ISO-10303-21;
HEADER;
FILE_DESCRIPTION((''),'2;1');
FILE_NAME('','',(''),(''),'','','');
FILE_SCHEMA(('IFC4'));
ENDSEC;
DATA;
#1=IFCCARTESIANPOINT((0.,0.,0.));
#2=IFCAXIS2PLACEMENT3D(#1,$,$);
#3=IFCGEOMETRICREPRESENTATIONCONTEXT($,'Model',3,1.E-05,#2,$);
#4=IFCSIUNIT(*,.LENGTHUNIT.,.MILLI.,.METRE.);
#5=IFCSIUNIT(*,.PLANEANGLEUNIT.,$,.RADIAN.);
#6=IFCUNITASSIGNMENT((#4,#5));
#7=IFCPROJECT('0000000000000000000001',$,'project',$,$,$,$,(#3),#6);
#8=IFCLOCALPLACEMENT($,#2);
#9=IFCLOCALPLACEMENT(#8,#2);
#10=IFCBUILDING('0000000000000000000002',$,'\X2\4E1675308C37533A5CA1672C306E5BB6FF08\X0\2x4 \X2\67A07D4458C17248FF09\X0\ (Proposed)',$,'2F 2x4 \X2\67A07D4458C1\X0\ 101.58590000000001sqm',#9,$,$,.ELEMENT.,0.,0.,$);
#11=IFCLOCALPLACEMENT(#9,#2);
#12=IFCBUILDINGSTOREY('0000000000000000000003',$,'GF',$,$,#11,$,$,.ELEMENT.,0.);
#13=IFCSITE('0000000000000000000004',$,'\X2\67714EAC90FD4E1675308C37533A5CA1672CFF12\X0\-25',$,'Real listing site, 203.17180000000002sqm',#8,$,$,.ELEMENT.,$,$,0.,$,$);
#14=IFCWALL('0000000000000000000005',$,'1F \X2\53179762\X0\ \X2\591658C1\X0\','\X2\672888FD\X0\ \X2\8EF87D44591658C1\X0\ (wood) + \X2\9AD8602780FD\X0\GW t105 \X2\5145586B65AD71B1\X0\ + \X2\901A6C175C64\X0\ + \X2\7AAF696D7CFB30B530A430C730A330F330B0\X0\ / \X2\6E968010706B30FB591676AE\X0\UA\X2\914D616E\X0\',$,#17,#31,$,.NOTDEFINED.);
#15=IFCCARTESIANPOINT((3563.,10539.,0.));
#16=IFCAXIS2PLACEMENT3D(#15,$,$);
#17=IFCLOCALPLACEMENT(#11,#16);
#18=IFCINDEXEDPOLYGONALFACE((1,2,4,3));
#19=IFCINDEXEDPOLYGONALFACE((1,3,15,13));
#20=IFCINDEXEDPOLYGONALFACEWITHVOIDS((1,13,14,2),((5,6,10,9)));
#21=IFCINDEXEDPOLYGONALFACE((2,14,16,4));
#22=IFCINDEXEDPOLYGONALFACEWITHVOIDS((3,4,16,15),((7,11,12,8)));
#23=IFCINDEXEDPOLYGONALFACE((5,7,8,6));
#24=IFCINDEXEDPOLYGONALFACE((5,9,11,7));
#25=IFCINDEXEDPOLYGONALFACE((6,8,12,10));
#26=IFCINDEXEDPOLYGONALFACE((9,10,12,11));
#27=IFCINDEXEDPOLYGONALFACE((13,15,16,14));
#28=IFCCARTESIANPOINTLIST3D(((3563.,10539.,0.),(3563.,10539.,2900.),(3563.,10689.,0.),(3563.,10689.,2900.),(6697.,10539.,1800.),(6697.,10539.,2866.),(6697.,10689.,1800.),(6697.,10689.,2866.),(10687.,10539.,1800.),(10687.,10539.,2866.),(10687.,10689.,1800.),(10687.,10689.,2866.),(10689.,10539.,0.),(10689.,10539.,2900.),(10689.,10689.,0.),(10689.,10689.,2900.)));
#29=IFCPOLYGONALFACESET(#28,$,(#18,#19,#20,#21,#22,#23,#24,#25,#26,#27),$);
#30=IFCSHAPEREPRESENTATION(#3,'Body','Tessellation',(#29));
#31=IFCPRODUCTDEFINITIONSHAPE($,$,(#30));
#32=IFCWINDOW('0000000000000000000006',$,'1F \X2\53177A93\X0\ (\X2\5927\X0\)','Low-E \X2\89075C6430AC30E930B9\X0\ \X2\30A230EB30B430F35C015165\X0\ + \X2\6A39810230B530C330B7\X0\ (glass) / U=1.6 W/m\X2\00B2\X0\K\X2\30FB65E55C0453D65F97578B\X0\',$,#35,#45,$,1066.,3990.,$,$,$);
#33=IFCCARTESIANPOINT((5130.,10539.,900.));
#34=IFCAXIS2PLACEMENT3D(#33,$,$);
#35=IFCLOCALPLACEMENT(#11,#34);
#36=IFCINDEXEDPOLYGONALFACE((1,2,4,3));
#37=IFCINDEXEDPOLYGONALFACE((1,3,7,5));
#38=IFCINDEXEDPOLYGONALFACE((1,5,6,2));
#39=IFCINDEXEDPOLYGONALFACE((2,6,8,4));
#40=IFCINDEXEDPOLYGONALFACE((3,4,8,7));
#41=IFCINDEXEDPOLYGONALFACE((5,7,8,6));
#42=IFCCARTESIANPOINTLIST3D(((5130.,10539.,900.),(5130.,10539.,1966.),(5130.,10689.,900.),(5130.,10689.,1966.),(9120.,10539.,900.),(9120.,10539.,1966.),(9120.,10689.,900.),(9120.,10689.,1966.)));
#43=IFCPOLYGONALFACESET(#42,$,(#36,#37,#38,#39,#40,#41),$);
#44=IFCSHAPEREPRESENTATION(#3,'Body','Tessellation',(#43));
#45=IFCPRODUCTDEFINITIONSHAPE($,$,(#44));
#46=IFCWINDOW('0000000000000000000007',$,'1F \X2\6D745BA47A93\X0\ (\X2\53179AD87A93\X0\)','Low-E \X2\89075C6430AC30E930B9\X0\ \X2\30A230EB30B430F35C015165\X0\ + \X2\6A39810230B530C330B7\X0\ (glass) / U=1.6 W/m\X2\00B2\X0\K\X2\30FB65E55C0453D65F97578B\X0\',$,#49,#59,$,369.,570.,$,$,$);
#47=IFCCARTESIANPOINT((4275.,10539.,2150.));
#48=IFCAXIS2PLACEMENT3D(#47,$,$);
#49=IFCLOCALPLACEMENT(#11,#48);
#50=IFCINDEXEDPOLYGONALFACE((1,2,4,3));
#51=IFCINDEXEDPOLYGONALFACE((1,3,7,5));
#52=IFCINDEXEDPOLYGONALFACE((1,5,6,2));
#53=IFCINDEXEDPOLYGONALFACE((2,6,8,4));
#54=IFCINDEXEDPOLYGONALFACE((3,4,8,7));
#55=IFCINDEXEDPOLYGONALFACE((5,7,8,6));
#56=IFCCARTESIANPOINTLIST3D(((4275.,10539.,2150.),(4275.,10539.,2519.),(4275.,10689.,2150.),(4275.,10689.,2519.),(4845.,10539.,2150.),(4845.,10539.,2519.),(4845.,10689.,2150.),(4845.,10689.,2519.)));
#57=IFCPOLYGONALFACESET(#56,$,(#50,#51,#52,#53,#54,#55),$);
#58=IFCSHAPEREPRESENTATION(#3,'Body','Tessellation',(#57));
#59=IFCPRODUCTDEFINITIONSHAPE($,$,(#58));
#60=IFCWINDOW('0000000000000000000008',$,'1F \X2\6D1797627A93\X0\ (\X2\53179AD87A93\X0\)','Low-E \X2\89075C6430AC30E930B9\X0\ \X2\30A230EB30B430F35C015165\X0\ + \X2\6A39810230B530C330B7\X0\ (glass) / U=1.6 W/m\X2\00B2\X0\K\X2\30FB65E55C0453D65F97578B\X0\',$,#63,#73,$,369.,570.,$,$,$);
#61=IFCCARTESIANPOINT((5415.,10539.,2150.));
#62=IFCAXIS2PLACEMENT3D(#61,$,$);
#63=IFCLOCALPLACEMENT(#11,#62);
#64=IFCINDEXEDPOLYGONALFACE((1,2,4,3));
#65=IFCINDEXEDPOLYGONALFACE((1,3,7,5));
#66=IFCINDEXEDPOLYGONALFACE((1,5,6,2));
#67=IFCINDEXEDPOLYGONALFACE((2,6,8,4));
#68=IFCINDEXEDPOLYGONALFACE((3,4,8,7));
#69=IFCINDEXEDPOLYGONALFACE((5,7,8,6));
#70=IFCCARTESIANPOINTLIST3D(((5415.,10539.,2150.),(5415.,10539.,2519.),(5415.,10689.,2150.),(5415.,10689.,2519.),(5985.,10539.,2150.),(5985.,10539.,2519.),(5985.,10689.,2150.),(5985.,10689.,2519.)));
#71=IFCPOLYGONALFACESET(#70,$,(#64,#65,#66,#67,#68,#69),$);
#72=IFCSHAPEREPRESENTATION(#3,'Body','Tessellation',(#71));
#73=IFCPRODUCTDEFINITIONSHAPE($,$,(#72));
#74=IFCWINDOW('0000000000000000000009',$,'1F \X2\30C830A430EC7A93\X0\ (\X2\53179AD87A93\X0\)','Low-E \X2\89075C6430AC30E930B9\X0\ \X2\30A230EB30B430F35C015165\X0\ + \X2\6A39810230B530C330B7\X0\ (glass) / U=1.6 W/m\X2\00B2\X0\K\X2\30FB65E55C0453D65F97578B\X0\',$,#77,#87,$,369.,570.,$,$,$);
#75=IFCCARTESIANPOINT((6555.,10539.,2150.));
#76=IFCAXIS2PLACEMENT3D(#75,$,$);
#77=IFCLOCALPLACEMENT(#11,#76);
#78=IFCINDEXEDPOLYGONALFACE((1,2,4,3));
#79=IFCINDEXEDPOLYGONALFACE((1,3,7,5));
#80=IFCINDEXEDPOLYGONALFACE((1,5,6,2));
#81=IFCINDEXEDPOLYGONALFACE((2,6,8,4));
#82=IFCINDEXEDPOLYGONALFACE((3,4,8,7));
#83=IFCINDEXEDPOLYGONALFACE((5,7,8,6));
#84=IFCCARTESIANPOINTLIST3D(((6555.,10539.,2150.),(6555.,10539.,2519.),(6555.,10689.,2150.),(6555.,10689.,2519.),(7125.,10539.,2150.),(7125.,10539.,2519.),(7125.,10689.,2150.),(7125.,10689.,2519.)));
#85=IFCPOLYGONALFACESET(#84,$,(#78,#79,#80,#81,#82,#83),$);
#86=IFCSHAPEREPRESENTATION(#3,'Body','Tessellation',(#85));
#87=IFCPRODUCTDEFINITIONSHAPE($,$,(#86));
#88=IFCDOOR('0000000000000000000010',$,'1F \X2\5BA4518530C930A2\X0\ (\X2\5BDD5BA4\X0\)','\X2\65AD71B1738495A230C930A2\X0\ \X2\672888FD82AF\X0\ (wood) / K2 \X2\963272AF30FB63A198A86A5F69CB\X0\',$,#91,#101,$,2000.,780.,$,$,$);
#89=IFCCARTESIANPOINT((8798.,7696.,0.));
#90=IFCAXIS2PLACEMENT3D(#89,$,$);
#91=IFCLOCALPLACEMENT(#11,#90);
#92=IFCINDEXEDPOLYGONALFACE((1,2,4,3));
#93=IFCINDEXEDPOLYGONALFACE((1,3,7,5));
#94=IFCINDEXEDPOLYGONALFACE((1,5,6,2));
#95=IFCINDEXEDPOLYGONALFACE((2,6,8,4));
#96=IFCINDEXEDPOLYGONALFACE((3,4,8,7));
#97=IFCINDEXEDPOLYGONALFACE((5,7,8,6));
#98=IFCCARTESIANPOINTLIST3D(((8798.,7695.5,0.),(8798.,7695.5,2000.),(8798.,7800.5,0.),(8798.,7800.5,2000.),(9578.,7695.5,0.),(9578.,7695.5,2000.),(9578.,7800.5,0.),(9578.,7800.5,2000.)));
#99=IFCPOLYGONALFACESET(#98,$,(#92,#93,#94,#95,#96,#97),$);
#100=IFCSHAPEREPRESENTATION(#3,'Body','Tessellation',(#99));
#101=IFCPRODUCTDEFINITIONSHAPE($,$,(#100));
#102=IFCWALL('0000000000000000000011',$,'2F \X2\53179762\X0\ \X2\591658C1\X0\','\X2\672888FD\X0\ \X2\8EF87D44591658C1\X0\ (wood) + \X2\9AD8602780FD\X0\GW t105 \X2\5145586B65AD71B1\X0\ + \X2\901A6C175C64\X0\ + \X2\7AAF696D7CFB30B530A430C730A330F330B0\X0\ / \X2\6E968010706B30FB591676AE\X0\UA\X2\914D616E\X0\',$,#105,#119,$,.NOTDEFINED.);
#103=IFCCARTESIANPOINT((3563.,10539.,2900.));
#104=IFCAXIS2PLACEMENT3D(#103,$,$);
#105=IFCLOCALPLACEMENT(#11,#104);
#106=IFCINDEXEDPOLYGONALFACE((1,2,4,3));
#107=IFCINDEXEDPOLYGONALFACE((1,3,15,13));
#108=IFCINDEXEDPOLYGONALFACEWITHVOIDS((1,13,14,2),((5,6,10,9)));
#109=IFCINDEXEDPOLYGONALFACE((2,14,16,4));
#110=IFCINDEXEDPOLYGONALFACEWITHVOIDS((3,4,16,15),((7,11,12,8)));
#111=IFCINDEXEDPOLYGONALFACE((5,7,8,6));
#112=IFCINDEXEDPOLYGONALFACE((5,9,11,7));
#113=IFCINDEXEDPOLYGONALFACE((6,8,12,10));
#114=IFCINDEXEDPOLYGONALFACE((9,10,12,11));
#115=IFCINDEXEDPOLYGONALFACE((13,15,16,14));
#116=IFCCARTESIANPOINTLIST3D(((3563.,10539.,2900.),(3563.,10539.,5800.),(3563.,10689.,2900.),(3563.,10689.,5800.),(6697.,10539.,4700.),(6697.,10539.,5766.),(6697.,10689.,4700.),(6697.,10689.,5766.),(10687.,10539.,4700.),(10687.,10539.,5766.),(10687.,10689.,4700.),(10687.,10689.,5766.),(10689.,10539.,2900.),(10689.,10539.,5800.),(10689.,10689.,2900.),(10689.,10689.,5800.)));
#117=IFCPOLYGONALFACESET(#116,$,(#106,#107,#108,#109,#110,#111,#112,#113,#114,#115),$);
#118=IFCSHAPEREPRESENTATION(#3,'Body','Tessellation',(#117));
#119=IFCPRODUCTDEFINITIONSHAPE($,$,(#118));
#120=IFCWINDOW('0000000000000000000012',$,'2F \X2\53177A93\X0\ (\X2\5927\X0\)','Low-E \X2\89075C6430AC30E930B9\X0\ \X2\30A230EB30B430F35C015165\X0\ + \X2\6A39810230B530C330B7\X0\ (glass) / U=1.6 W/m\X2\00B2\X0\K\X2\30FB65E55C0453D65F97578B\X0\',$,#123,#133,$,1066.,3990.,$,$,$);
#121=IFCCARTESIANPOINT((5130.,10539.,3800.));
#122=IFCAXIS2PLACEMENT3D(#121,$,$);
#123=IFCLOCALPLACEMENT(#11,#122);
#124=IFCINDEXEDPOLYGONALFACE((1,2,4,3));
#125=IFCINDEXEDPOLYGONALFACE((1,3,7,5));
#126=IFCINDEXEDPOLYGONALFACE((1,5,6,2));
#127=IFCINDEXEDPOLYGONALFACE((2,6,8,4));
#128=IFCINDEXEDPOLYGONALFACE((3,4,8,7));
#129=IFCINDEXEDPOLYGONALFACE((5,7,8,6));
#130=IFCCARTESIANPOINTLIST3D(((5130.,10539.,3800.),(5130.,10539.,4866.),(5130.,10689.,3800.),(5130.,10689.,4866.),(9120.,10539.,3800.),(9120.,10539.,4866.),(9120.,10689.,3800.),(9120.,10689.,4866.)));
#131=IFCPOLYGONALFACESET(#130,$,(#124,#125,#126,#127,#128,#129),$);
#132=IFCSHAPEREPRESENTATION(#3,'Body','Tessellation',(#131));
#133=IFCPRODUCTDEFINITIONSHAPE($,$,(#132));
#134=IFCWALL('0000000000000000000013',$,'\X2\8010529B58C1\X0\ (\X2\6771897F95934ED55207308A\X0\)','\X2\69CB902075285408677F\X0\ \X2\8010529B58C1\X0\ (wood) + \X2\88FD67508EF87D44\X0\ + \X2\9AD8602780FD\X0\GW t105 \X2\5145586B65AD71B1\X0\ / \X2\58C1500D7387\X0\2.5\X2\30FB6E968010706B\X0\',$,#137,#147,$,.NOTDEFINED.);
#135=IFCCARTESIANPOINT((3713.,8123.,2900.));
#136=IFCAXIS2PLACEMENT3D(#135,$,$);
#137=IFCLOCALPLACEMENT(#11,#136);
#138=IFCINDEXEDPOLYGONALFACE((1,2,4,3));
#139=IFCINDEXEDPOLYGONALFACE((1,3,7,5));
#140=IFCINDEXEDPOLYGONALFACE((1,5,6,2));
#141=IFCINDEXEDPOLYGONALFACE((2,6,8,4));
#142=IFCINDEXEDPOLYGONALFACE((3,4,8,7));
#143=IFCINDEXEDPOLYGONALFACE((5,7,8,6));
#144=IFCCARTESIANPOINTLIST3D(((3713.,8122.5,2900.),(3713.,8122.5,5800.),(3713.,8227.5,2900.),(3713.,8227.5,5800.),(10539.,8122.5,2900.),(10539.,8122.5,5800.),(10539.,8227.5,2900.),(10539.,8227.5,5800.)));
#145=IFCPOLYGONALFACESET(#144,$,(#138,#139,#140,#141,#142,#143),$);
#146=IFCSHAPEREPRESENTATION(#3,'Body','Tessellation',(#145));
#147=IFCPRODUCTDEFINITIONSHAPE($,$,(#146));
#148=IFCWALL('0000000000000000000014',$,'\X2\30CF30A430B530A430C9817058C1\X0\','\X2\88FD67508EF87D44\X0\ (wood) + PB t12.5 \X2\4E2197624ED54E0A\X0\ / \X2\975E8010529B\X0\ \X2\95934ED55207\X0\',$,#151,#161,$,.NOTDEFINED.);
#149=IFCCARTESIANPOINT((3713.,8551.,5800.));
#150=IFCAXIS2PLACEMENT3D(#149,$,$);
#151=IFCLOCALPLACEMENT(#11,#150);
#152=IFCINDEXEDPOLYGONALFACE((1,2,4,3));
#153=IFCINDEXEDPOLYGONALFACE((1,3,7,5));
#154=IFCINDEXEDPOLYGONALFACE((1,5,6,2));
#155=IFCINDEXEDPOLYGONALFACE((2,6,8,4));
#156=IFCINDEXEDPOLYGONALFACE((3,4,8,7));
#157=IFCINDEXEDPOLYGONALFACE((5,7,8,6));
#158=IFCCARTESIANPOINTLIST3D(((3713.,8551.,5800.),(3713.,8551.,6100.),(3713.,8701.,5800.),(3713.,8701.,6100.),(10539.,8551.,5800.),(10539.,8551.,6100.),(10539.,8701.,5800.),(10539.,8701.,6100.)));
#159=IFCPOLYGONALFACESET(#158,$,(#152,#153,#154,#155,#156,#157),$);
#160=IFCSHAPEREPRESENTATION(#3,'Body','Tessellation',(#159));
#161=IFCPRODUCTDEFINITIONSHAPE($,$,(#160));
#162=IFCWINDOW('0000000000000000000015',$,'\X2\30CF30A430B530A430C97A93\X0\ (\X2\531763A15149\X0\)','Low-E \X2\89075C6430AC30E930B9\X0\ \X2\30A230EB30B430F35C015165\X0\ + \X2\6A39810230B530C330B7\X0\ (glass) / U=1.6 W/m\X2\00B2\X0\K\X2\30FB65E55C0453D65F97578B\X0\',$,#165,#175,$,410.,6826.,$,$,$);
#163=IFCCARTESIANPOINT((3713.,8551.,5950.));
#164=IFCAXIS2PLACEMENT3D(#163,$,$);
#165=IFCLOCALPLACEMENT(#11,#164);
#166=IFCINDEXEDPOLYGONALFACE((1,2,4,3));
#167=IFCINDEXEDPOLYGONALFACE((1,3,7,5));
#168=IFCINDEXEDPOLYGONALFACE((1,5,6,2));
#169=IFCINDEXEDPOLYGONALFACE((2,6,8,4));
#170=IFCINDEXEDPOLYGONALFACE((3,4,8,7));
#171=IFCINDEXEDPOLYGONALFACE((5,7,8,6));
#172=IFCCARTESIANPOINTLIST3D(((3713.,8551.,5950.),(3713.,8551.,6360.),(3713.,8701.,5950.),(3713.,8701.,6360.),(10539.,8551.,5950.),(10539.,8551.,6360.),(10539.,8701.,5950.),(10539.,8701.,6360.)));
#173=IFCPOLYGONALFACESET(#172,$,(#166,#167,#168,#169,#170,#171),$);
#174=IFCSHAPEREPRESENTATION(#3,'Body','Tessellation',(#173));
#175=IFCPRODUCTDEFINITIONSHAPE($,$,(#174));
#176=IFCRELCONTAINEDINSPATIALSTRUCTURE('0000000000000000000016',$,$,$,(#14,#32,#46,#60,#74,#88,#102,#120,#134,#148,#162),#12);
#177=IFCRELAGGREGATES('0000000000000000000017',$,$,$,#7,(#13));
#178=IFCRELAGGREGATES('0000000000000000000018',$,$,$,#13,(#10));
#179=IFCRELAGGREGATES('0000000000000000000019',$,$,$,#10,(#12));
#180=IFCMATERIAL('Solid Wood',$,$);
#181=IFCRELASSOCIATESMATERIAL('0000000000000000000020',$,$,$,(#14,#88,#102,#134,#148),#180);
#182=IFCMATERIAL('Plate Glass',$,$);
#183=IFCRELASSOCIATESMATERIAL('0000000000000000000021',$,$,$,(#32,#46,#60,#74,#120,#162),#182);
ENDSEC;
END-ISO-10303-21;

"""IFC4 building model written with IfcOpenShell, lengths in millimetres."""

from ifc_helpers import new_model, si_unit, frame, frame_2d, origin, place, context, project, spatial, rectangle, extrude, material, element, fill, save


model = new_model("IFC4")

# Units and contexts
model_context = context("Model", 3, precision=1e-05, world=origin())
ifc_project = project(units=[si_unit("LENGTHUNIT", "METRE", prefix="MILLI"), si_unit("PLANEANGLEUNIT", "RADIAN")], contexts=[model_context])

# Site, building, storey
site_placement = place(None, origin())
site = spatial("IfcSite", under=ifc_project, at=site_placement, Name="東京都世田谷区岡本２-25", ObjectType="Real listing site, 203.17180000000002sqm", CompositionType="ELEMENT", RefElevation=0.0)
building_placement = place(site_placement, origin())
building = spatial("IfcBuilding", under=site, at=building_placement, Name="世田谷区岡本の家（2x4 枠組壁版） (Proposed)", ObjectType="2F 2x4 枠組壁 101.58590000000001sqm", CompositionType="ELEMENT", ElevationOfRefHeight=0.0, ElevationOfTerrain=0.0)
storey_placement = place(building_placement, origin())
storey = spatial("IfcBuildingStorey", under=building, at=storey_placement, Name="GF", CompositionType="ELEMENT", Elevation=0.0)

# Wall, openings, windows
ifc_material_1 = material(Name="Solid Wood")
wall_1_placement = place(storey_placement, frame((3563.0, 10539.0, 0.0)))
wall_1 = element("IfcWall", 1, at=wall_1_placement, inside=storey, material=ifc_material_1, Name="1F 北面 外壁", Description="木製 軸組外壁 (wood) + 高性能GW t105 充填断熱 + 通気層 + 窯業系サイディング / 準耐火・外皮UA配慮", PredefinedType="NOTDEFINED", context=model_context, shape_type="SweptSolid", body=[
    extrude(rectangle(XDim=7126.0, YDim=150.0, at=frame_2d((3563.0, 75.0))), frame((3563.0, 10539.0, 0.0)), (0.0, 0.0, 1.0), 2900.0),
])
opening_1_placement = place(storey_placement, frame((5130.0, 10539.0, 900.0)))
opening_1 = element("IfcOpeningElement", 2, at=opening_1_placement, cuts=wall_1, PredefinedType="NOTDEFINED", context=model_context, shape_type="SweptSolid", body=[
    extrude(rectangle(XDim=3990.0, YDim=150.0, at=frame_2d((1995.0, 75.0))), frame((5130.0, 10539.0, 900.0)), (0.0, 0.0, 1.0), 1066.0),
])
opening_2_placement = place(storey_placement, frame((4275.0, 10539.0, 2150.0)))
opening_2 = element("IfcOpeningElement", 3, at=opening_2_placement, cuts=wall_1, PredefinedType="NOTDEFINED", context=model_context, shape_type="SweptSolid", body=[
    extrude(rectangle(XDim=570.0, YDim=150.0, at=frame_2d((285.0, 75.0))), frame((4275.0, 10539.0, 2150.0)), (0.0, 0.0, 1.0), 369.0),
])
opening_3_placement = place(storey_placement, frame((5415.0, 10539.0, 2150.0)))
opening_3 = element("IfcOpeningElement", 4, at=opening_3_placement, cuts=wall_1, PredefinedType="NOTDEFINED", context=model_context, shape_type="SweptSolid", body=[
    extrude(rectangle(XDim=570.0, YDim=150.0, at=frame_2d((285.0, 75.0))), frame((5415.0, 10539.0, 2150.0)), (0.0, 0.0, 1.0), 369.0),
])
opening_4_placement = place(storey_placement, frame((6555.0, 10539.0, 2150.0)))
opening_4 = element("IfcOpeningElement", 5, at=opening_4_placement, cuts=wall_1, PredefinedType="NOTDEFINED", context=model_context, shape_type="SweptSolid", body=[
    extrude(rectangle(XDim=570.0, YDim=150.0, at=frame_2d((285.0, 75.0))), frame((6555.0, 10539.0, 2150.0)), (0.0, 0.0, 1.0), 369.0),
])
ifc_material_2 = material(Name="Plate Glass")
window_1_placement = place(storey_placement, frame((5130.0, 10539.0, 900.0)))
window_1 = element("IfcWindow", 6, at=window_1_placement, inside=storey, material=ifc_material_2, Name="1F 北窓 (大)", Description="Low-E 複層ガラス アルゴン封入 + 樹脂サッシ (glass) / U=1.6 W/m²K・日射取得型", OverallHeight=1066.0, OverallWidth=3990.0, context=model_context, shape_type="SweptSolid", body=[
    extrude(rectangle(XDim=3990.0, YDim=150.0, at=frame_2d((1995.0, 75.0))), frame((5130.0, 10539.0, 900.0)), (0.0, 0.0, 1.0), 1066.0),
])
fill(opening_1, window_1)
window_2_placement = place(storey_placement, frame((4275.0, 10539.0, 2150.0)))
window_2 = element("IfcWindow", 7, at=window_2_placement, inside=storey, material=ifc_material_2, Name="1F 浴室窓 (北高窓)", Description="Low-E 複層ガラス アルゴン封入 + 樹脂サッシ (glass) / U=1.6 W/m²K・日射取得型", OverallHeight=369.0, OverallWidth=570.0, context=model_context, shape_type="SweptSolid", body=[
    extrude(rectangle(XDim=570.0, YDim=150.0, at=frame_2d((285.0, 75.0))), frame((4275.0, 10539.0, 2150.0)), (0.0, 0.0, 1.0), 369.0),
])
fill(opening_2, window_2)
window_3_placement = place(storey_placement, frame((5415.0, 10539.0, 2150.0)))
window_3 = element("IfcWindow", 8, at=window_3_placement, inside=storey, material=ifc_material_2, Name="1F 洗面窓 (北高窓)", Description="Low-E 複層ガラス アルゴン封入 + 樹脂サッシ (glass) / U=1.6 W/m²K・日射取得型", OverallHeight=369.0, OverallWidth=570.0, context=model_context, shape_type="SweptSolid", body=[
    extrude(rectangle(XDim=570.0, YDim=150.0, at=frame_2d((285.0, 75.0))), frame((5415.0, 10539.0, 2150.0)), (0.0, 0.0, 1.0), 369.0),
])
fill(opening_3, window_3)
window_4_placement = place(storey_placement, frame((6555.0, 10539.0, 2150.0)))
window_4 = element("IfcWindow", 9, at=window_4_placement, inside=storey, material=ifc_material_2, Name="1F トイレ窓 (北高窓)", Description="Low-E 複層ガラス アルゴン封入 + 樹脂サッシ (glass) / U=1.6 W/m²K・日射取得型", OverallHeight=369.0, OverallWidth=570.0, context=model_context, shape_type="SweptSolid", body=[
    extrude(rectangle(XDim=570.0, YDim=150.0, at=frame_2d((285.0, 75.0))), frame((6555.0, 10539.0, 2150.0)), (0.0, 0.0, 1.0), 369.0),
])
fill(opening_4, window_4)

# Door
door_1_placement = place(storey_placement, frame((8798.0, 7696.0, 0.0)))
element("IfcDoor", 10, at=door_1_placement, inside=storey, material=ifc_material_1, Name="1F 室内ドア (寝室)", Description="断熱玄関ドア 木製芯 (wood) / K2 防犯・採風機構", OverallHeight=2000.0, OverallWidth=780.0, context=model_context, shape_type="SweptSolid", body=[
    extrude(rectangle(XDim=780.0, YDim=105.0, at=frame_2d((390.0, 52.0))), frame((8798.0, 7696.0, 0.0)), (0.0, 0.0, 1.0), 2000.0),
])

# Wall, opening, window
wall_2_placement = place(storey_placement, frame((3563.0, 10539.0, 2900.0)))
wall_2 = element("IfcWall", 11, at=wall_2_placement, inside=storey, material=ifc_material_1, Name="2F 北面 外壁", Description="木製 軸組外壁 (wood) + 高性能GW t105 充填断熱 + 通気層 + 窯業系サイディング / 準耐火・外皮UA配慮", PredefinedType="NOTDEFINED", context=model_context, shape_type="SweptSolid", body=[
    extrude(rectangle(XDim=7126.0, YDim=150.0, at=frame_2d((3563.0, 75.0))), frame((3563.0, 10539.0, 2900.0)), (0.0, 0.0, 1.0), 2900.0),
])
opening_5_placement = place(storey_placement, frame((5130.0, 10539.0, 3800.0)))
opening_5 = element("IfcOpeningElement", 12, at=opening_5_placement, cuts=wall_2, PredefinedType="NOTDEFINED", context=model_context, shape_type="SweptSolid", body=[
    extrude(rectangle(XDim=3990.0, YDim=150.0, at=frame_2d((1995.0, 75.0))), frame((5130.0, 10539.0, 3800.0)), (0.0, 0.0, 1.0), 1066.0),
])
window_5_placement = place(storey_placement, frame((5130.0, 10539.0, 3800.0)))
window_5 = element("IfcWindow", 13, at=window_5_placement, inside=storey, material=ifc_material_2, Name="2F 北窓 (大)", Description="Low-E 複層ガラス アルゴン封入 + 樹脂サッシ (glass) / U=1.6 W/m²K・日射取得型", OverallHeight=1066.0, OverallWidth=3990.0, context=model_context, shape_type="SweptSolid", body=[
    extrude(rectangle(XDim=3990.0, YDim=150.0, at=frame_2d((1995.0, 75.0))), frame((5130.0, 10539.0, 3800.0)), (0.0, 0.0, 1.0), 1066.0),
])
fill(opening_5, window_5)

# Wall
wall_3_placement = place(storey_placement, frame((3713.0, 8123.0, 2900.0)))
element("IfcWall", 14, at=wall_3_placement, inside=storey, material=ifc_material_1, Name="耐力壁 (東西間仕切り)", Description="構造用合板 耐力壁 (wood) + 製材軸組 + 高性能GW t105 充填断熱 / 壁倍率2.5・準耐火", PredefinedType="NOTDEFINED", context=model_context, shape_type="SweptSolid", body=[
    extrude(rectangle(XDim=6826.0, YDim=105.0, at=frame_2d((3413.0, 52.0))), frame((3713.0, 8123.0, 2900.0)), (0.0, 0.0, 1.0), 2900.0),
])

# Wall, opening, window
wall_4_placement = place(storey_placement, frame((3713.0, 8551.0, 5800.0)))
wall_4 = element("IfcWall", 15, at=wall_4_placement, inside=storey, material=ifc_material_1, Name="ハイサイド腰壁", Description="製材軸組 (wood) + PB t12.5 両面仕上 / 非耐力 間仕切", PredefinedType="NOTDEFINED", context=model_context, shape_type="SweptSolid", body=[
    extrude(rectangle(XDim=6826.0, YDim=150.0, at=frame_2d((3413.0, 75.0))), frame((3713.0, 8551.0, 5800.0)), (0.0, 0.0, 1.0), 700.0),
])
opening_6_placement = place(storey_placement, frame((3713.0, 8551.0, 5950.0)))
opening_6 = element("IfcOpeningElement", 16, at=opening_6_placement, cuts=wall_4, PredefinedType="NOTDEFINED", context=model_context, shape_type="SweptSolid", body=[
    extrude(rectangle(XDim=6826.0, YDim=150.0, at=frame_2d((3413.0, 75.0))), frame((3713.0, 8551.0, 5950.0)), (0.0, 0.0, 1.0), 410.0),
])
window_6_placement = place(storey_placement, frame((3713.0, 8551.0, 5950.0)))
window_6 = element("IfcWindow", 17, at=window_6_placement, inside=storey, material=ifc_material_2, Name="ハイサイド窓 (北採光)", Description="Low-E 複層ガラス アルゴン封入 + 樹脂サッシ (glass) / U=1.6 W/m²K・日射取得型", OverallHeight=410.0, OverallWidth=6826.0, context=model_context, shape_type="SweptSolid", body=[
    extrude(rectangle(XDim=6826.0, YDim=150.0, at=frame_2d((3413.0, 75.0))), frame((3713.0, 8551.0, 5950.0)), (0.0, 0.0, 1.0), 410.0),
])
fill(opening_6, window_6)

save(model, "model.ifc")
